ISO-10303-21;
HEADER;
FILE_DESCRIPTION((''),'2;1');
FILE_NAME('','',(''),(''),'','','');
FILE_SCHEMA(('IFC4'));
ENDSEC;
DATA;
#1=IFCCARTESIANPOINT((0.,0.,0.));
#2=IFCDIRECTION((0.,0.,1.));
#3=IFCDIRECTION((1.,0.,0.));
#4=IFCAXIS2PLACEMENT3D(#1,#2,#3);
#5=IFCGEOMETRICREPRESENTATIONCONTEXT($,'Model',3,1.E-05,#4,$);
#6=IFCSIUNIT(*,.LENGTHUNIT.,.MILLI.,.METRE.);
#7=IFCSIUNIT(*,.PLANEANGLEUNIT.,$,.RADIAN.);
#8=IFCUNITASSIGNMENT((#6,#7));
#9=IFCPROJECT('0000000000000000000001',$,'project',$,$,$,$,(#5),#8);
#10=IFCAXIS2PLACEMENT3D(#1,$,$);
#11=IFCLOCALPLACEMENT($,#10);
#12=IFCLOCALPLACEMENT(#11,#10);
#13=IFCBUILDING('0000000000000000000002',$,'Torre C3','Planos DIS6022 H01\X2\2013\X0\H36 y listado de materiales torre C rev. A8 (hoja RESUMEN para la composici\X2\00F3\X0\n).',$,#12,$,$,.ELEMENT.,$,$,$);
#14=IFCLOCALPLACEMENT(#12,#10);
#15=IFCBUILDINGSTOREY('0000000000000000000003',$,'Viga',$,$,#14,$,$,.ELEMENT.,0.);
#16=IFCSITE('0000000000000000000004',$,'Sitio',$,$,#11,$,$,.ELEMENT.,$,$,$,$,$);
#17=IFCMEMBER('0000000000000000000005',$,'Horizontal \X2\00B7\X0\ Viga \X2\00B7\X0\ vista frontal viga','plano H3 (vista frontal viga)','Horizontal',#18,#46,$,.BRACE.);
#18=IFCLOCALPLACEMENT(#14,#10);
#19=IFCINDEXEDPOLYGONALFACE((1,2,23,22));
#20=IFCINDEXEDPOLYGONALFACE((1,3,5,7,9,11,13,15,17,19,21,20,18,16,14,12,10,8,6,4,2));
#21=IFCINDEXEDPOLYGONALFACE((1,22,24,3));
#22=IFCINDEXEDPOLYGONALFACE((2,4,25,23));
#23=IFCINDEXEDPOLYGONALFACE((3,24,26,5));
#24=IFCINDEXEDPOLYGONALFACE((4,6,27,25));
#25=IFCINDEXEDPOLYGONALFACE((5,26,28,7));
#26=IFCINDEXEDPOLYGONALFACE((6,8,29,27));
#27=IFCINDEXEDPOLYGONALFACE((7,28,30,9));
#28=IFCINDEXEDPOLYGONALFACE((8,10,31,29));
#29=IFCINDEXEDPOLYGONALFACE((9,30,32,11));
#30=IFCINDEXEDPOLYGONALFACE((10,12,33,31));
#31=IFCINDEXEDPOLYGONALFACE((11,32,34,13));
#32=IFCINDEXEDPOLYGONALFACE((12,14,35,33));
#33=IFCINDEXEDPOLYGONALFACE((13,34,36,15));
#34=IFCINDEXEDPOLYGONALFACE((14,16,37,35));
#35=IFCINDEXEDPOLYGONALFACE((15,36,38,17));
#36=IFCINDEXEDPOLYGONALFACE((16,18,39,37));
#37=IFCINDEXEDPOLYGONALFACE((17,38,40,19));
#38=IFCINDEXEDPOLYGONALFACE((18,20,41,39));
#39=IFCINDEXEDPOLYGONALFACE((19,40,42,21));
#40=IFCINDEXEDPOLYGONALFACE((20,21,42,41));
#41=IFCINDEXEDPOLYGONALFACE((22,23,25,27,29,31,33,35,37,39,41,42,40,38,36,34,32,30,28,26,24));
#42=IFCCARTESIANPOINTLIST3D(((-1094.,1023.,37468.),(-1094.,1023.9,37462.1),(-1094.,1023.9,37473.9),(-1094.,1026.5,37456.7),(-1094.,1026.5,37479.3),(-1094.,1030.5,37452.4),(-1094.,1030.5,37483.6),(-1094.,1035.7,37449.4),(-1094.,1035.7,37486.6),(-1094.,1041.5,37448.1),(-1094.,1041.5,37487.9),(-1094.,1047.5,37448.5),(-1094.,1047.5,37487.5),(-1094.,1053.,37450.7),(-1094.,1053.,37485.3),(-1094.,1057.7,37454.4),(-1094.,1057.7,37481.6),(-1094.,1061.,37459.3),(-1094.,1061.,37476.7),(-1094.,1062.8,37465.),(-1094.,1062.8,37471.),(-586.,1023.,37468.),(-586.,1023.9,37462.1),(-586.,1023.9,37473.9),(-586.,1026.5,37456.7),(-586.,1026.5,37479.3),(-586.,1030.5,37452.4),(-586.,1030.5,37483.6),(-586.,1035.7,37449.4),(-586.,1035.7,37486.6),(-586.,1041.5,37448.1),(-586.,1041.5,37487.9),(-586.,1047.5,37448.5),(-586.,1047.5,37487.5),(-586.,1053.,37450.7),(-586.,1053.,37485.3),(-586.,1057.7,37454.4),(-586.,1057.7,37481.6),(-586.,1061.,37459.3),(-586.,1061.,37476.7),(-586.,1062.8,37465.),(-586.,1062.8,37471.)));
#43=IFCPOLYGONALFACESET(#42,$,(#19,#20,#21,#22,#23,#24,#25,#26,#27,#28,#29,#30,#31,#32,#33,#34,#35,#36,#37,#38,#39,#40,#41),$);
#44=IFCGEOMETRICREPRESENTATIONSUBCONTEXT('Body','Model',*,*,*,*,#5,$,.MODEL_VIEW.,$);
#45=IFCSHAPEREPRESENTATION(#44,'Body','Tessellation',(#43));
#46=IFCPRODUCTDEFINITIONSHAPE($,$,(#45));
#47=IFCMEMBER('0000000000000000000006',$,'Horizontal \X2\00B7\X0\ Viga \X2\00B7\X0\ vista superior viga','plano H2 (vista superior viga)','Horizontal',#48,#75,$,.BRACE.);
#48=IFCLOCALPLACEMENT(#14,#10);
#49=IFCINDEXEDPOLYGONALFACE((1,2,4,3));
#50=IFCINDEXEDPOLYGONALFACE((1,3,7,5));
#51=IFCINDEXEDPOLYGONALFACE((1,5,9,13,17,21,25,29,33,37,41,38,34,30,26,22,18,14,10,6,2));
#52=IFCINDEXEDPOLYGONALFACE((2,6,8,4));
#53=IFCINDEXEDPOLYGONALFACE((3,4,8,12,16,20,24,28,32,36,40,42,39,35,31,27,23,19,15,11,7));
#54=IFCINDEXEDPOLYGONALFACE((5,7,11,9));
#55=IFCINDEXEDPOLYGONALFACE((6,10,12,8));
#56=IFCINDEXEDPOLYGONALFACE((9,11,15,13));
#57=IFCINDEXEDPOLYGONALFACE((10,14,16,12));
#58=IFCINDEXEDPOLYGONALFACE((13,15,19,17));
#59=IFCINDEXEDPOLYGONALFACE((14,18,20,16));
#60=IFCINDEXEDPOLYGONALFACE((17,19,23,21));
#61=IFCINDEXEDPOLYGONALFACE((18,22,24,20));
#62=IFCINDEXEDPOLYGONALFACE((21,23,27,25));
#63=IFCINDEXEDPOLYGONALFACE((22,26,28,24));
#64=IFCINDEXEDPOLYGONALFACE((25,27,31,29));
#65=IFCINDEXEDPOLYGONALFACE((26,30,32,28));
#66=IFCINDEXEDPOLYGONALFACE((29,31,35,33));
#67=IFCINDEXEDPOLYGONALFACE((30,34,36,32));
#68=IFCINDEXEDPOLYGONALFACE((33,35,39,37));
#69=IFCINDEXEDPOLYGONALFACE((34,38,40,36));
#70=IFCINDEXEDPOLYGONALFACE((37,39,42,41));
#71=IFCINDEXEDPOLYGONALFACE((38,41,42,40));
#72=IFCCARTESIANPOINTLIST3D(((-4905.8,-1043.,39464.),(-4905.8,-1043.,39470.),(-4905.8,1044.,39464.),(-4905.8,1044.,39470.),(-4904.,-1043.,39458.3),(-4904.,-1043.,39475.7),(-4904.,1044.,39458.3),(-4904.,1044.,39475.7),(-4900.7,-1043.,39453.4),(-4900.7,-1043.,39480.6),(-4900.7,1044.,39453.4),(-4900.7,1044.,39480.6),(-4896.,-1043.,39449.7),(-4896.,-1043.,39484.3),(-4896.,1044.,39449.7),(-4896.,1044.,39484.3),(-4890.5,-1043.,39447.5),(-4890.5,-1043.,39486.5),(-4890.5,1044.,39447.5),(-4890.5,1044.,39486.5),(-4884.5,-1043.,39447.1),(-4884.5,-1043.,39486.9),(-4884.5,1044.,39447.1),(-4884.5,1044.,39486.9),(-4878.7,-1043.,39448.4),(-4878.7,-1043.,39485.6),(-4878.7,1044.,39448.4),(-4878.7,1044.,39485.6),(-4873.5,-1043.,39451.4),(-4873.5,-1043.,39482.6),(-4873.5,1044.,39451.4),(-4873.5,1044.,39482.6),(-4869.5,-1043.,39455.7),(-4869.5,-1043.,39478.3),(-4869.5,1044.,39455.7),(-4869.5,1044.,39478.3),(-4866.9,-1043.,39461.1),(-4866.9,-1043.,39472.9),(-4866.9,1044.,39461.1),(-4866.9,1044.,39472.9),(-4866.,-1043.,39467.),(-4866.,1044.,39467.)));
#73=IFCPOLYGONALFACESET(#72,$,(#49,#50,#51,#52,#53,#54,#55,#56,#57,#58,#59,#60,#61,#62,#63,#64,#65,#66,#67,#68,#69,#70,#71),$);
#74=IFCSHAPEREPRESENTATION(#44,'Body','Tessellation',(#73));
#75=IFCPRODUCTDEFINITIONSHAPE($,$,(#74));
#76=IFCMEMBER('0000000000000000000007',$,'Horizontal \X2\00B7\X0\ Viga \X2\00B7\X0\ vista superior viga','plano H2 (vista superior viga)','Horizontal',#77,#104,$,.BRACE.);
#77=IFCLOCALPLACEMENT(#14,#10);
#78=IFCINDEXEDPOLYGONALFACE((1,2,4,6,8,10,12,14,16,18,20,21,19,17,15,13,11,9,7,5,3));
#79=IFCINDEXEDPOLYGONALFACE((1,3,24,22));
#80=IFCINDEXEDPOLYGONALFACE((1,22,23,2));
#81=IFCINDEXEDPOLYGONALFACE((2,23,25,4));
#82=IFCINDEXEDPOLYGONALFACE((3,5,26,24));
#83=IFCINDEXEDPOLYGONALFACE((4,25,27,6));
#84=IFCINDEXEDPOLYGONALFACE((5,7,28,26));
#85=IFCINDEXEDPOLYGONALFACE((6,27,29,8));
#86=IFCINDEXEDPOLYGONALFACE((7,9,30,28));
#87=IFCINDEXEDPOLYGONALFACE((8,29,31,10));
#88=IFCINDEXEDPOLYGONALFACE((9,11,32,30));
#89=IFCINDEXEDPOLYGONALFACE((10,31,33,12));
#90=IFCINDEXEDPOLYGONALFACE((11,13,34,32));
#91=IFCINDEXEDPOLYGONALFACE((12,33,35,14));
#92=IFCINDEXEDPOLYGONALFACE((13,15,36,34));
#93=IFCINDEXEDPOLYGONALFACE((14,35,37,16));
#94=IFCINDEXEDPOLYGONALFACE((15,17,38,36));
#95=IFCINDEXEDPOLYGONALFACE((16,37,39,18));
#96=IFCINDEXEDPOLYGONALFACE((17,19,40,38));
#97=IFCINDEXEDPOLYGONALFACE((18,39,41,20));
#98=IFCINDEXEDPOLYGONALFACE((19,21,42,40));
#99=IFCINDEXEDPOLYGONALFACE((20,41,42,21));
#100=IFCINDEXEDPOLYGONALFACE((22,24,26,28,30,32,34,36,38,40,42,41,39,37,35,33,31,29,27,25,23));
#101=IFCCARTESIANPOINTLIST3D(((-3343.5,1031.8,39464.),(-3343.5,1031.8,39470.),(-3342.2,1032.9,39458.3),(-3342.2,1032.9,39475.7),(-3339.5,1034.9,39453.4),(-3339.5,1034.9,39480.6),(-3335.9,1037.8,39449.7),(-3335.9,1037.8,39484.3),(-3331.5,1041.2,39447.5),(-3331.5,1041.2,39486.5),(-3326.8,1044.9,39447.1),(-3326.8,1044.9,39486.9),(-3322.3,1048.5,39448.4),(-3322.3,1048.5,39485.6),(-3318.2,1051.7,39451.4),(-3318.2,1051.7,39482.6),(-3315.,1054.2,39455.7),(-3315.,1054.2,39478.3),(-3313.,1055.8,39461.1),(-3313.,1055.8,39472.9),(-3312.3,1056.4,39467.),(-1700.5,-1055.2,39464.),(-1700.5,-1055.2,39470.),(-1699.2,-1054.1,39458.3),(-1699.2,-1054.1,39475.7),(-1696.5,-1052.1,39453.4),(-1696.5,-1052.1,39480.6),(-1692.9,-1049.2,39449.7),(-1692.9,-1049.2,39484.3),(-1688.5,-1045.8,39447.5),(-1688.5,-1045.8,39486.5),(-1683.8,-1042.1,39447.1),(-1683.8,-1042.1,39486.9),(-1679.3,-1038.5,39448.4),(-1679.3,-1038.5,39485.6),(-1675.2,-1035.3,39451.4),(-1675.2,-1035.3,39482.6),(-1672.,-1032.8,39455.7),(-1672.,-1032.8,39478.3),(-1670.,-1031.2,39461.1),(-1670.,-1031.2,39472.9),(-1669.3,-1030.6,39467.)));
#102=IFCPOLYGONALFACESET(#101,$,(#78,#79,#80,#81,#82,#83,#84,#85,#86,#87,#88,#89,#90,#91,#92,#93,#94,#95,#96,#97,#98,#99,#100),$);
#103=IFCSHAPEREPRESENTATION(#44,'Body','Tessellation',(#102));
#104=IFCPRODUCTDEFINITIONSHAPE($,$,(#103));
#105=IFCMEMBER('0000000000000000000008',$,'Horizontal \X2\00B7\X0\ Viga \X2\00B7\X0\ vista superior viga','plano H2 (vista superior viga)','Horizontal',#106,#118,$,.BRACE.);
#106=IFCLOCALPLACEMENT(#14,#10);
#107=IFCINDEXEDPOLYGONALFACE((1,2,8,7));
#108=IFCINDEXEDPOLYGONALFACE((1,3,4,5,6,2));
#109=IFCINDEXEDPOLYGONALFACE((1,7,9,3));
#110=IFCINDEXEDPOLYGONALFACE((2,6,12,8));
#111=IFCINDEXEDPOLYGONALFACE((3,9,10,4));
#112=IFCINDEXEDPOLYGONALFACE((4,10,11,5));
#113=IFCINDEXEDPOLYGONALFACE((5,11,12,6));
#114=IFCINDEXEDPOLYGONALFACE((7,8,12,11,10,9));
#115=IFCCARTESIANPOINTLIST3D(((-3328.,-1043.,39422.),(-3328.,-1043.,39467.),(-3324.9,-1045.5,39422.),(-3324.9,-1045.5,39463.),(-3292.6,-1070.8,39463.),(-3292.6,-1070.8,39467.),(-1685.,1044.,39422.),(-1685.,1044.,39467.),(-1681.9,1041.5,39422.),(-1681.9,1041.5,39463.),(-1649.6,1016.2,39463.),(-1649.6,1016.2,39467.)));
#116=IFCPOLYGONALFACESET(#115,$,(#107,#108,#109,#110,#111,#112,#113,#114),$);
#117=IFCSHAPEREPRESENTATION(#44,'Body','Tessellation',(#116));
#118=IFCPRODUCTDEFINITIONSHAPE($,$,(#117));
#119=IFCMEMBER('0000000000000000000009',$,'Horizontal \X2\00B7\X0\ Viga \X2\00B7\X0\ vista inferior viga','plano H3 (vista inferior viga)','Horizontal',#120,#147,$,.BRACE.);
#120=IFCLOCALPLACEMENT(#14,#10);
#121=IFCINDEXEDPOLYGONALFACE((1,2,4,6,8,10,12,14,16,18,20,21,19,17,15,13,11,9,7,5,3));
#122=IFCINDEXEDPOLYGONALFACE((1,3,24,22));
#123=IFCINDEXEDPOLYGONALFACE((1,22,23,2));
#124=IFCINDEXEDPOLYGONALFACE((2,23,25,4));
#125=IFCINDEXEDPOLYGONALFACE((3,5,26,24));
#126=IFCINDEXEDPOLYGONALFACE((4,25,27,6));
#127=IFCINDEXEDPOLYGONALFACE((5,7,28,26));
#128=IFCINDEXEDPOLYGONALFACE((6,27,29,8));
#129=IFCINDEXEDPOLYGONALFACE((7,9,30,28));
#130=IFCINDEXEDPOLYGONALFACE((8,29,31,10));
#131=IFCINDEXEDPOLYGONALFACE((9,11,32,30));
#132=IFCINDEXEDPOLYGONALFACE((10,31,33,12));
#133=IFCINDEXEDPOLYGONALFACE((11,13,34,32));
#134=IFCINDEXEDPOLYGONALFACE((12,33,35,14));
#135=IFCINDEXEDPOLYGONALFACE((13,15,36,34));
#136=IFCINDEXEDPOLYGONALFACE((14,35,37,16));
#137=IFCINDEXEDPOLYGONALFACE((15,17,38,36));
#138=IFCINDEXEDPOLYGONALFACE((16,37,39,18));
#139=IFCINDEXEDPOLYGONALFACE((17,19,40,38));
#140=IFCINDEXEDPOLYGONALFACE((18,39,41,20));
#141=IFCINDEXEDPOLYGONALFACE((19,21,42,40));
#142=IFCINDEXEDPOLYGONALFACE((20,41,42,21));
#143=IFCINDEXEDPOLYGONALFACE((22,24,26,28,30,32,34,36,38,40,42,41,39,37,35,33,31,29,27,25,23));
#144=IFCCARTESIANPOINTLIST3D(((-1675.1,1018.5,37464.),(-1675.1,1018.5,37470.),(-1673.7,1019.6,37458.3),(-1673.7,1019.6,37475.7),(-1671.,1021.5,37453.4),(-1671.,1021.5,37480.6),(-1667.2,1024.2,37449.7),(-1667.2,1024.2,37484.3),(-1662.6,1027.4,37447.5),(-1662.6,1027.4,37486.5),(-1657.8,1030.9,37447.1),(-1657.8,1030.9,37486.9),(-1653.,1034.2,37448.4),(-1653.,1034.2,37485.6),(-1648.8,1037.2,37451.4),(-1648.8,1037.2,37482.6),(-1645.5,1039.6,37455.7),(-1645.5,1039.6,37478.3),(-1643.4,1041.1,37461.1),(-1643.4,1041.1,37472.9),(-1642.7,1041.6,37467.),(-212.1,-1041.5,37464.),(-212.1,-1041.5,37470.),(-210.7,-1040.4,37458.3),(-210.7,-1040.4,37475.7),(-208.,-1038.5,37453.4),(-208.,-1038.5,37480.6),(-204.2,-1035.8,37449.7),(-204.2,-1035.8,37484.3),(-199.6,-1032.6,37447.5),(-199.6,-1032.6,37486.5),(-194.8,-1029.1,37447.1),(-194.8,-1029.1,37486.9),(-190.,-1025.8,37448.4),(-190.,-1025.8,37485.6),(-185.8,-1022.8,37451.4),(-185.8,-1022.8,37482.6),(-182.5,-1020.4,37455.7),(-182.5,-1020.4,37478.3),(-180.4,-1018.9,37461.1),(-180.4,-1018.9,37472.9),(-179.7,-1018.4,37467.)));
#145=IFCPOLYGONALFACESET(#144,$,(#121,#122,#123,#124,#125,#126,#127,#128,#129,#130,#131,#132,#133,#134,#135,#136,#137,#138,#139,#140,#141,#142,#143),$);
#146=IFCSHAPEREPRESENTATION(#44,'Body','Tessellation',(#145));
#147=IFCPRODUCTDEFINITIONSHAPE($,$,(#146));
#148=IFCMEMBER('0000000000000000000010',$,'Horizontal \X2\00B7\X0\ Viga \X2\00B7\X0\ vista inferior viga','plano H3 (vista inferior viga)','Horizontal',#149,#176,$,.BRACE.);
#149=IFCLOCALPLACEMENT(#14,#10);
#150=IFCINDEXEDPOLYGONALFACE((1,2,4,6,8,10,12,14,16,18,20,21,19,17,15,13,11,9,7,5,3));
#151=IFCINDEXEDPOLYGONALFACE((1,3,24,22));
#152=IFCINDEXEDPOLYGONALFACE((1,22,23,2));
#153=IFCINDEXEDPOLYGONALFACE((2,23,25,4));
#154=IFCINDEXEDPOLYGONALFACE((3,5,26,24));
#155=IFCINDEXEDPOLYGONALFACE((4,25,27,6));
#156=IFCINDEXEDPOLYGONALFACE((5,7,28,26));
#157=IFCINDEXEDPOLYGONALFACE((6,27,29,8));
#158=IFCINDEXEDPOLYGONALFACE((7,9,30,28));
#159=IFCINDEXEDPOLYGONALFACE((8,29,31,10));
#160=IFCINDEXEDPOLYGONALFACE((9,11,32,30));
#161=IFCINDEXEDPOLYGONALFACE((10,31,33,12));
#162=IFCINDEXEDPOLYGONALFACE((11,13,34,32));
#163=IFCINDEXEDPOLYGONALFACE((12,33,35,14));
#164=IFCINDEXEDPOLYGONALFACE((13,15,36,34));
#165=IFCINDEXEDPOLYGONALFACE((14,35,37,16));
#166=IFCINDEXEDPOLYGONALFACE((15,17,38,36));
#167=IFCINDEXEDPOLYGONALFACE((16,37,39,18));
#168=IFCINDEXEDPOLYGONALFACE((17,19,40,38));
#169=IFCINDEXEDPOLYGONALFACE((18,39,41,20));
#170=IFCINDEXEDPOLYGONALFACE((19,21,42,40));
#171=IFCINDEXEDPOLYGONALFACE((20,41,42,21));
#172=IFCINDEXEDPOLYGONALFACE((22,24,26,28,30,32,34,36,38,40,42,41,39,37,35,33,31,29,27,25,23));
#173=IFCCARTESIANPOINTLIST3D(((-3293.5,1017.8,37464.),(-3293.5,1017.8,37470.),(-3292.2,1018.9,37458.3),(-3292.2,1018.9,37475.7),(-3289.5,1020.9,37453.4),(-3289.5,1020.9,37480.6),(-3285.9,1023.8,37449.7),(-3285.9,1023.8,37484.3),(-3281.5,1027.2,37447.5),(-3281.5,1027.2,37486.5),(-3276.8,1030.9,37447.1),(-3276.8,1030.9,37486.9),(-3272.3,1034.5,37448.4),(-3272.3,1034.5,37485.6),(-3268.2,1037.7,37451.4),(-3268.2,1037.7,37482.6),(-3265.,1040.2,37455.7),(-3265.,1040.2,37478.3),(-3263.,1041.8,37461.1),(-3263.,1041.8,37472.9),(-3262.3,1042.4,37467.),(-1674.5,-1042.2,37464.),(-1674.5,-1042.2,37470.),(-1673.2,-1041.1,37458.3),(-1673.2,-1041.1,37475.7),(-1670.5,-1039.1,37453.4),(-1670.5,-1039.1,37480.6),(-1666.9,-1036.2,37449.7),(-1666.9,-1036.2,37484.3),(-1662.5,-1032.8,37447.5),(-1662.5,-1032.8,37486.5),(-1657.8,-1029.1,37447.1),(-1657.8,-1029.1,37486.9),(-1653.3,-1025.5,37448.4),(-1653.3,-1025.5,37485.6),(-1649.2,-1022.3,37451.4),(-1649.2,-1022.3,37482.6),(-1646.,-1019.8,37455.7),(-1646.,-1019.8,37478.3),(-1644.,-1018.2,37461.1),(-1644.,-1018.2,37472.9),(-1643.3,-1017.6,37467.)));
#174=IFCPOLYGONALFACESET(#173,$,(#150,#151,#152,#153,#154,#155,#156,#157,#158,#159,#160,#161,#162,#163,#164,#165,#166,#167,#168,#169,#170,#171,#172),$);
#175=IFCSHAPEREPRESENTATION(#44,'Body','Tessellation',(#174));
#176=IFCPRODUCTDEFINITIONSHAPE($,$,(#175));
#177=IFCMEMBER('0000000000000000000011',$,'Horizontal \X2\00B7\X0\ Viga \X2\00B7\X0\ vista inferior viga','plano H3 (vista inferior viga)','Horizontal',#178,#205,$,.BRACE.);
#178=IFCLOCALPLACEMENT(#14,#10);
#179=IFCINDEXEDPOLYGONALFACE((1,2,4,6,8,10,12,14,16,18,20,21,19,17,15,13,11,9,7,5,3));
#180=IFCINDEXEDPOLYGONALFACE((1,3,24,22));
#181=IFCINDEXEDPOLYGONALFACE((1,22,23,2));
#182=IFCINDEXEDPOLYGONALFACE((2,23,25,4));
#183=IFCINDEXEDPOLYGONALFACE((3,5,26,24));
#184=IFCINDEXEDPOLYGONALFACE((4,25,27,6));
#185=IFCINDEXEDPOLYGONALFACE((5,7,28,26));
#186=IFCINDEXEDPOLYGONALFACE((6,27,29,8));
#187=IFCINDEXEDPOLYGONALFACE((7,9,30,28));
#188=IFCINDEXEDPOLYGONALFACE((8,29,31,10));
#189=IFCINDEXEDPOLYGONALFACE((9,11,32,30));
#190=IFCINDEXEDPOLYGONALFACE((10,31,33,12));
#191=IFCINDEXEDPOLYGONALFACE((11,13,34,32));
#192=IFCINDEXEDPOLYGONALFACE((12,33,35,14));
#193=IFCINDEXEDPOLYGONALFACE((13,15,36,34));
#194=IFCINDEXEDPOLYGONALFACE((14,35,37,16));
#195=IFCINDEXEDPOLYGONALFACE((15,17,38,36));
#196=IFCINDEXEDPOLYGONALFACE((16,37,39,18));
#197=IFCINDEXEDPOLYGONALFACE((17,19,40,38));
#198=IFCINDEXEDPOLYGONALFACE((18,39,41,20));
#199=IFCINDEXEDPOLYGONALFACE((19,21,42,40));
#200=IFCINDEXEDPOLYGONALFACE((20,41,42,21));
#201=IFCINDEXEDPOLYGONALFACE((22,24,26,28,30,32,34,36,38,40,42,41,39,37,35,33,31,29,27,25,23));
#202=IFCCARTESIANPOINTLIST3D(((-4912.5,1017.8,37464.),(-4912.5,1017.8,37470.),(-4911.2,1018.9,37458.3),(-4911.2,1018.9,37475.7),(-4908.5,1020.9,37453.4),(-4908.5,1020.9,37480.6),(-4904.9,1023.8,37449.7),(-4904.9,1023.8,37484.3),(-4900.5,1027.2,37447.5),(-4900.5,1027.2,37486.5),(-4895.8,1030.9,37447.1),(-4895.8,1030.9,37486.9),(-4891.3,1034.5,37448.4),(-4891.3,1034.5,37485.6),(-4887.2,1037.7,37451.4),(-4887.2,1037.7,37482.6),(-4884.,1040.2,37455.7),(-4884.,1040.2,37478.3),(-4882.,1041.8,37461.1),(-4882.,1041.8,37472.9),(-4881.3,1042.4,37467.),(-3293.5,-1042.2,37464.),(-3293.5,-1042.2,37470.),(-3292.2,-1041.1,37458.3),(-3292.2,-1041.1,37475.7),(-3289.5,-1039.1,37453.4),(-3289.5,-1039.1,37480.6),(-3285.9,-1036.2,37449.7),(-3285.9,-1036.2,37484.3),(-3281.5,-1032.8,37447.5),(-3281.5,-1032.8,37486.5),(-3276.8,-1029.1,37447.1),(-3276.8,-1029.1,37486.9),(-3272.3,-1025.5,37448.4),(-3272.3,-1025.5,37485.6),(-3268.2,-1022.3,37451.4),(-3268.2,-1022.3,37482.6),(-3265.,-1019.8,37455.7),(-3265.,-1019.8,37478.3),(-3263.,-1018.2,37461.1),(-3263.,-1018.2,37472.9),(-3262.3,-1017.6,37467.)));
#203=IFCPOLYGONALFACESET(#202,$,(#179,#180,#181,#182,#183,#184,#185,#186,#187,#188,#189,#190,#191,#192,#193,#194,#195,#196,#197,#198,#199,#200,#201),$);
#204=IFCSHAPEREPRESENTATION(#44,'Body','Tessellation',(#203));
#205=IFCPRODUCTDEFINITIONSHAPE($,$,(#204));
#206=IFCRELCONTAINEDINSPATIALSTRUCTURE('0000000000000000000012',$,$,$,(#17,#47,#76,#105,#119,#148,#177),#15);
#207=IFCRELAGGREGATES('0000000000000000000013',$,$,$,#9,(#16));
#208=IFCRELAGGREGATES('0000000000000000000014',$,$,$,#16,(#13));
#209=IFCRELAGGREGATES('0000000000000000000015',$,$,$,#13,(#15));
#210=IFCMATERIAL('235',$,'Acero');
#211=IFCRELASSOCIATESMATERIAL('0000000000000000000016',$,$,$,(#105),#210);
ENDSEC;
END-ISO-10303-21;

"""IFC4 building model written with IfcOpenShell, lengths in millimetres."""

from ifc_helpers import new_model, si_unit, frame, frame_2d, origin, origin_with_axes, place, context, subcontext, project, spatial, circle, l_section, extrude, material, element, save


model = new_model("IFC4")

# Units and contexts
model_context = context("Model", 3, precision=1e-05, world=origin_with_axes())
body_context = subcontext(model_context, "Body", "Model", "MODEL_VIEW")
ifc_project = project(units=[si_unit("LENGTHUNIT", "METRE", prefix="MILLI"), si_unit("PLANEANGLEUNIT", "RADIAN")], contexts=[model_context])

# Site, building, storey
site_placement = place(None, origin())
site = spatial("IfcSite", under=ifc_project, at=site_placement, Name="Sitio", CompositionType="ELEMENT")
building_placement = place(site_placement, origin())
building = spatial("IfcBuilding", under=site, at=building_placement, Name="Torre C3", Description="Planos DIS6022 H01–H36 y listado de materiales torre C rev. A8 (hoja RESUMEN para la composición).", CompositionType="ELEMENT")
storey_placement = place(building_placement, origin())
storey = spatial("IfcBuildingStorey", under=building, at=storey_placement, Name="Viga", CompositionType="ELEMENT", Elevation=0.0)

# Members
for number, where, z_axis, x_axis, name in (
    (1, (-1094.0, 1043.0, 37468.0), (1.0, 0.0, 0.0), (0.0, -1.0, 0.0), "Horizontal · Viga · vista frontal viga"),
):
    element("IfcMember", number, at=place(storey_placement, frame(where, z_axis=z_axis, x_axis=x_axis)), inside=storey, Name=name, Description="plano H3 (vista frontal viga)", ObjectType="Horizontal", PredefinedType="BRACE", context=body_context, shape_type="SweptSolid", body=[
        extrude(circle(Radius=20.0), None, (0.0, 0.0, 1.0), 508.0),
    ])
member_1_placement = place(storey_placement, frame((-4886.0, 1044.0, 39467.0), z_axis=(0.0, -1.0, 0.0), x_axis=(1.0, 0.0, 0.0)))
element("IfcMember", 2, at=member_1_placement, inside=storey, Name="Horizontal · Viga · vista superior viga", Description="plano H2 (vista superior viga)", ObjectType="Horizontal", PredefinedType="BRACE", context=body_context, shape_type="SweptSolid", body=[
    extrude(circle(Radius=20.0), None, (0.0, 0.0, 1.0), 2087.0),
])
member_2_placement = place(storey_placement, frame((-3328.0, 1044.0, 39467.0), z_axis=(0.618569, -0.78573, 0.0), x_axis=(0.78573, 0.618569, 0.0)))
element("IfcMember", 3, at=member_2_placement, inside=storey, Name="Horizontal · Viga · vista superior viga", Description="plano H2 (vista superior viga)", ObjectType="Horizontal", PredefinedType="BRACE", context=body_context, shape_type="SweptSolid", body=[
    extrude(circle(Radius=20.0), None, (0.0, 0.0, 1.0), 2656.1),
])
ifc_material_1 = material(Name="235", Category="Acero")
member_3_placement = place(storey_placement, frame((-3328.0, -1043.0, 39467.0), z_axis=(0.618569, 0.78573, 0.0), x_axis=(0.78573, -0.618569, 0.0)))
element("IfcMember", 4, at=member_3_placement, inside=storey, material=ifc_material_1, Name="Horizontal · Viga · vista superior viga", Description="plano H2 (vista superior viga)", ObjectType="Horizontal", PredefinedType="BRACE", context=body_context, shape_type="SweptSolid", body=[
    extrude(l_section(Depth=45.0, Width=45.0, Thickness=4.0, at=frame_2d((22.5, 22.5))), None, (0.0, 0.0, 1.0), 2656.1),
])
member_4_placement = place(storey_placement, frame((-1659.0, 1030.0, 37467.0), z_axis=(0.579027, -0.815308, 0.0), x_axis=(0.815308, 0.579027, 0.0)))
element("IfcMember", 5, at=member_4_placement, inside=storey, Name="Horizontal · Viga · vista inferior viga", Description="plano H3 (vista inferior viga)", ObjectType="Horizontal", PredefinedType="BRACE", context=body_context, shape_type="SweptSolid", body=[
    extrude(circle(Radius=20.0), None, (0.0, 0.0, 1.0), 2526.7),
])
for number, where, z_axis, x_axis, name in (
    (6, (-3278.0, 1030.0, 37467.0), (0.617923, -0.786239, 0.0), (0.786239, 0.617923, 0.0), "Horizontal · Viga · vista inferior viga"),
    (7, (-4897.0, 1030.0, 37467.0), (0.617923, -0.786239, 0.0), (0.786239, 0.617923, 0.0), "Horizontal · Viga · vista inferior viga"),
):
    element("IfcMember", number, at=place(storey_placement, frame(where, z_axis=z_axis, x_axis=x_axis)), inside=storey, Name=name, Description="plano H3 (vista inferior viga)", ObjectType="Horizontal", PredefinedType="BRACE", context=body_context, shape_type="SweptSolid", body=[
        extrude(circle(Radius=20.0), None, (0.0, 0.0, 1.0), 2620.1),
    ])

save(model, "model.ifc")
